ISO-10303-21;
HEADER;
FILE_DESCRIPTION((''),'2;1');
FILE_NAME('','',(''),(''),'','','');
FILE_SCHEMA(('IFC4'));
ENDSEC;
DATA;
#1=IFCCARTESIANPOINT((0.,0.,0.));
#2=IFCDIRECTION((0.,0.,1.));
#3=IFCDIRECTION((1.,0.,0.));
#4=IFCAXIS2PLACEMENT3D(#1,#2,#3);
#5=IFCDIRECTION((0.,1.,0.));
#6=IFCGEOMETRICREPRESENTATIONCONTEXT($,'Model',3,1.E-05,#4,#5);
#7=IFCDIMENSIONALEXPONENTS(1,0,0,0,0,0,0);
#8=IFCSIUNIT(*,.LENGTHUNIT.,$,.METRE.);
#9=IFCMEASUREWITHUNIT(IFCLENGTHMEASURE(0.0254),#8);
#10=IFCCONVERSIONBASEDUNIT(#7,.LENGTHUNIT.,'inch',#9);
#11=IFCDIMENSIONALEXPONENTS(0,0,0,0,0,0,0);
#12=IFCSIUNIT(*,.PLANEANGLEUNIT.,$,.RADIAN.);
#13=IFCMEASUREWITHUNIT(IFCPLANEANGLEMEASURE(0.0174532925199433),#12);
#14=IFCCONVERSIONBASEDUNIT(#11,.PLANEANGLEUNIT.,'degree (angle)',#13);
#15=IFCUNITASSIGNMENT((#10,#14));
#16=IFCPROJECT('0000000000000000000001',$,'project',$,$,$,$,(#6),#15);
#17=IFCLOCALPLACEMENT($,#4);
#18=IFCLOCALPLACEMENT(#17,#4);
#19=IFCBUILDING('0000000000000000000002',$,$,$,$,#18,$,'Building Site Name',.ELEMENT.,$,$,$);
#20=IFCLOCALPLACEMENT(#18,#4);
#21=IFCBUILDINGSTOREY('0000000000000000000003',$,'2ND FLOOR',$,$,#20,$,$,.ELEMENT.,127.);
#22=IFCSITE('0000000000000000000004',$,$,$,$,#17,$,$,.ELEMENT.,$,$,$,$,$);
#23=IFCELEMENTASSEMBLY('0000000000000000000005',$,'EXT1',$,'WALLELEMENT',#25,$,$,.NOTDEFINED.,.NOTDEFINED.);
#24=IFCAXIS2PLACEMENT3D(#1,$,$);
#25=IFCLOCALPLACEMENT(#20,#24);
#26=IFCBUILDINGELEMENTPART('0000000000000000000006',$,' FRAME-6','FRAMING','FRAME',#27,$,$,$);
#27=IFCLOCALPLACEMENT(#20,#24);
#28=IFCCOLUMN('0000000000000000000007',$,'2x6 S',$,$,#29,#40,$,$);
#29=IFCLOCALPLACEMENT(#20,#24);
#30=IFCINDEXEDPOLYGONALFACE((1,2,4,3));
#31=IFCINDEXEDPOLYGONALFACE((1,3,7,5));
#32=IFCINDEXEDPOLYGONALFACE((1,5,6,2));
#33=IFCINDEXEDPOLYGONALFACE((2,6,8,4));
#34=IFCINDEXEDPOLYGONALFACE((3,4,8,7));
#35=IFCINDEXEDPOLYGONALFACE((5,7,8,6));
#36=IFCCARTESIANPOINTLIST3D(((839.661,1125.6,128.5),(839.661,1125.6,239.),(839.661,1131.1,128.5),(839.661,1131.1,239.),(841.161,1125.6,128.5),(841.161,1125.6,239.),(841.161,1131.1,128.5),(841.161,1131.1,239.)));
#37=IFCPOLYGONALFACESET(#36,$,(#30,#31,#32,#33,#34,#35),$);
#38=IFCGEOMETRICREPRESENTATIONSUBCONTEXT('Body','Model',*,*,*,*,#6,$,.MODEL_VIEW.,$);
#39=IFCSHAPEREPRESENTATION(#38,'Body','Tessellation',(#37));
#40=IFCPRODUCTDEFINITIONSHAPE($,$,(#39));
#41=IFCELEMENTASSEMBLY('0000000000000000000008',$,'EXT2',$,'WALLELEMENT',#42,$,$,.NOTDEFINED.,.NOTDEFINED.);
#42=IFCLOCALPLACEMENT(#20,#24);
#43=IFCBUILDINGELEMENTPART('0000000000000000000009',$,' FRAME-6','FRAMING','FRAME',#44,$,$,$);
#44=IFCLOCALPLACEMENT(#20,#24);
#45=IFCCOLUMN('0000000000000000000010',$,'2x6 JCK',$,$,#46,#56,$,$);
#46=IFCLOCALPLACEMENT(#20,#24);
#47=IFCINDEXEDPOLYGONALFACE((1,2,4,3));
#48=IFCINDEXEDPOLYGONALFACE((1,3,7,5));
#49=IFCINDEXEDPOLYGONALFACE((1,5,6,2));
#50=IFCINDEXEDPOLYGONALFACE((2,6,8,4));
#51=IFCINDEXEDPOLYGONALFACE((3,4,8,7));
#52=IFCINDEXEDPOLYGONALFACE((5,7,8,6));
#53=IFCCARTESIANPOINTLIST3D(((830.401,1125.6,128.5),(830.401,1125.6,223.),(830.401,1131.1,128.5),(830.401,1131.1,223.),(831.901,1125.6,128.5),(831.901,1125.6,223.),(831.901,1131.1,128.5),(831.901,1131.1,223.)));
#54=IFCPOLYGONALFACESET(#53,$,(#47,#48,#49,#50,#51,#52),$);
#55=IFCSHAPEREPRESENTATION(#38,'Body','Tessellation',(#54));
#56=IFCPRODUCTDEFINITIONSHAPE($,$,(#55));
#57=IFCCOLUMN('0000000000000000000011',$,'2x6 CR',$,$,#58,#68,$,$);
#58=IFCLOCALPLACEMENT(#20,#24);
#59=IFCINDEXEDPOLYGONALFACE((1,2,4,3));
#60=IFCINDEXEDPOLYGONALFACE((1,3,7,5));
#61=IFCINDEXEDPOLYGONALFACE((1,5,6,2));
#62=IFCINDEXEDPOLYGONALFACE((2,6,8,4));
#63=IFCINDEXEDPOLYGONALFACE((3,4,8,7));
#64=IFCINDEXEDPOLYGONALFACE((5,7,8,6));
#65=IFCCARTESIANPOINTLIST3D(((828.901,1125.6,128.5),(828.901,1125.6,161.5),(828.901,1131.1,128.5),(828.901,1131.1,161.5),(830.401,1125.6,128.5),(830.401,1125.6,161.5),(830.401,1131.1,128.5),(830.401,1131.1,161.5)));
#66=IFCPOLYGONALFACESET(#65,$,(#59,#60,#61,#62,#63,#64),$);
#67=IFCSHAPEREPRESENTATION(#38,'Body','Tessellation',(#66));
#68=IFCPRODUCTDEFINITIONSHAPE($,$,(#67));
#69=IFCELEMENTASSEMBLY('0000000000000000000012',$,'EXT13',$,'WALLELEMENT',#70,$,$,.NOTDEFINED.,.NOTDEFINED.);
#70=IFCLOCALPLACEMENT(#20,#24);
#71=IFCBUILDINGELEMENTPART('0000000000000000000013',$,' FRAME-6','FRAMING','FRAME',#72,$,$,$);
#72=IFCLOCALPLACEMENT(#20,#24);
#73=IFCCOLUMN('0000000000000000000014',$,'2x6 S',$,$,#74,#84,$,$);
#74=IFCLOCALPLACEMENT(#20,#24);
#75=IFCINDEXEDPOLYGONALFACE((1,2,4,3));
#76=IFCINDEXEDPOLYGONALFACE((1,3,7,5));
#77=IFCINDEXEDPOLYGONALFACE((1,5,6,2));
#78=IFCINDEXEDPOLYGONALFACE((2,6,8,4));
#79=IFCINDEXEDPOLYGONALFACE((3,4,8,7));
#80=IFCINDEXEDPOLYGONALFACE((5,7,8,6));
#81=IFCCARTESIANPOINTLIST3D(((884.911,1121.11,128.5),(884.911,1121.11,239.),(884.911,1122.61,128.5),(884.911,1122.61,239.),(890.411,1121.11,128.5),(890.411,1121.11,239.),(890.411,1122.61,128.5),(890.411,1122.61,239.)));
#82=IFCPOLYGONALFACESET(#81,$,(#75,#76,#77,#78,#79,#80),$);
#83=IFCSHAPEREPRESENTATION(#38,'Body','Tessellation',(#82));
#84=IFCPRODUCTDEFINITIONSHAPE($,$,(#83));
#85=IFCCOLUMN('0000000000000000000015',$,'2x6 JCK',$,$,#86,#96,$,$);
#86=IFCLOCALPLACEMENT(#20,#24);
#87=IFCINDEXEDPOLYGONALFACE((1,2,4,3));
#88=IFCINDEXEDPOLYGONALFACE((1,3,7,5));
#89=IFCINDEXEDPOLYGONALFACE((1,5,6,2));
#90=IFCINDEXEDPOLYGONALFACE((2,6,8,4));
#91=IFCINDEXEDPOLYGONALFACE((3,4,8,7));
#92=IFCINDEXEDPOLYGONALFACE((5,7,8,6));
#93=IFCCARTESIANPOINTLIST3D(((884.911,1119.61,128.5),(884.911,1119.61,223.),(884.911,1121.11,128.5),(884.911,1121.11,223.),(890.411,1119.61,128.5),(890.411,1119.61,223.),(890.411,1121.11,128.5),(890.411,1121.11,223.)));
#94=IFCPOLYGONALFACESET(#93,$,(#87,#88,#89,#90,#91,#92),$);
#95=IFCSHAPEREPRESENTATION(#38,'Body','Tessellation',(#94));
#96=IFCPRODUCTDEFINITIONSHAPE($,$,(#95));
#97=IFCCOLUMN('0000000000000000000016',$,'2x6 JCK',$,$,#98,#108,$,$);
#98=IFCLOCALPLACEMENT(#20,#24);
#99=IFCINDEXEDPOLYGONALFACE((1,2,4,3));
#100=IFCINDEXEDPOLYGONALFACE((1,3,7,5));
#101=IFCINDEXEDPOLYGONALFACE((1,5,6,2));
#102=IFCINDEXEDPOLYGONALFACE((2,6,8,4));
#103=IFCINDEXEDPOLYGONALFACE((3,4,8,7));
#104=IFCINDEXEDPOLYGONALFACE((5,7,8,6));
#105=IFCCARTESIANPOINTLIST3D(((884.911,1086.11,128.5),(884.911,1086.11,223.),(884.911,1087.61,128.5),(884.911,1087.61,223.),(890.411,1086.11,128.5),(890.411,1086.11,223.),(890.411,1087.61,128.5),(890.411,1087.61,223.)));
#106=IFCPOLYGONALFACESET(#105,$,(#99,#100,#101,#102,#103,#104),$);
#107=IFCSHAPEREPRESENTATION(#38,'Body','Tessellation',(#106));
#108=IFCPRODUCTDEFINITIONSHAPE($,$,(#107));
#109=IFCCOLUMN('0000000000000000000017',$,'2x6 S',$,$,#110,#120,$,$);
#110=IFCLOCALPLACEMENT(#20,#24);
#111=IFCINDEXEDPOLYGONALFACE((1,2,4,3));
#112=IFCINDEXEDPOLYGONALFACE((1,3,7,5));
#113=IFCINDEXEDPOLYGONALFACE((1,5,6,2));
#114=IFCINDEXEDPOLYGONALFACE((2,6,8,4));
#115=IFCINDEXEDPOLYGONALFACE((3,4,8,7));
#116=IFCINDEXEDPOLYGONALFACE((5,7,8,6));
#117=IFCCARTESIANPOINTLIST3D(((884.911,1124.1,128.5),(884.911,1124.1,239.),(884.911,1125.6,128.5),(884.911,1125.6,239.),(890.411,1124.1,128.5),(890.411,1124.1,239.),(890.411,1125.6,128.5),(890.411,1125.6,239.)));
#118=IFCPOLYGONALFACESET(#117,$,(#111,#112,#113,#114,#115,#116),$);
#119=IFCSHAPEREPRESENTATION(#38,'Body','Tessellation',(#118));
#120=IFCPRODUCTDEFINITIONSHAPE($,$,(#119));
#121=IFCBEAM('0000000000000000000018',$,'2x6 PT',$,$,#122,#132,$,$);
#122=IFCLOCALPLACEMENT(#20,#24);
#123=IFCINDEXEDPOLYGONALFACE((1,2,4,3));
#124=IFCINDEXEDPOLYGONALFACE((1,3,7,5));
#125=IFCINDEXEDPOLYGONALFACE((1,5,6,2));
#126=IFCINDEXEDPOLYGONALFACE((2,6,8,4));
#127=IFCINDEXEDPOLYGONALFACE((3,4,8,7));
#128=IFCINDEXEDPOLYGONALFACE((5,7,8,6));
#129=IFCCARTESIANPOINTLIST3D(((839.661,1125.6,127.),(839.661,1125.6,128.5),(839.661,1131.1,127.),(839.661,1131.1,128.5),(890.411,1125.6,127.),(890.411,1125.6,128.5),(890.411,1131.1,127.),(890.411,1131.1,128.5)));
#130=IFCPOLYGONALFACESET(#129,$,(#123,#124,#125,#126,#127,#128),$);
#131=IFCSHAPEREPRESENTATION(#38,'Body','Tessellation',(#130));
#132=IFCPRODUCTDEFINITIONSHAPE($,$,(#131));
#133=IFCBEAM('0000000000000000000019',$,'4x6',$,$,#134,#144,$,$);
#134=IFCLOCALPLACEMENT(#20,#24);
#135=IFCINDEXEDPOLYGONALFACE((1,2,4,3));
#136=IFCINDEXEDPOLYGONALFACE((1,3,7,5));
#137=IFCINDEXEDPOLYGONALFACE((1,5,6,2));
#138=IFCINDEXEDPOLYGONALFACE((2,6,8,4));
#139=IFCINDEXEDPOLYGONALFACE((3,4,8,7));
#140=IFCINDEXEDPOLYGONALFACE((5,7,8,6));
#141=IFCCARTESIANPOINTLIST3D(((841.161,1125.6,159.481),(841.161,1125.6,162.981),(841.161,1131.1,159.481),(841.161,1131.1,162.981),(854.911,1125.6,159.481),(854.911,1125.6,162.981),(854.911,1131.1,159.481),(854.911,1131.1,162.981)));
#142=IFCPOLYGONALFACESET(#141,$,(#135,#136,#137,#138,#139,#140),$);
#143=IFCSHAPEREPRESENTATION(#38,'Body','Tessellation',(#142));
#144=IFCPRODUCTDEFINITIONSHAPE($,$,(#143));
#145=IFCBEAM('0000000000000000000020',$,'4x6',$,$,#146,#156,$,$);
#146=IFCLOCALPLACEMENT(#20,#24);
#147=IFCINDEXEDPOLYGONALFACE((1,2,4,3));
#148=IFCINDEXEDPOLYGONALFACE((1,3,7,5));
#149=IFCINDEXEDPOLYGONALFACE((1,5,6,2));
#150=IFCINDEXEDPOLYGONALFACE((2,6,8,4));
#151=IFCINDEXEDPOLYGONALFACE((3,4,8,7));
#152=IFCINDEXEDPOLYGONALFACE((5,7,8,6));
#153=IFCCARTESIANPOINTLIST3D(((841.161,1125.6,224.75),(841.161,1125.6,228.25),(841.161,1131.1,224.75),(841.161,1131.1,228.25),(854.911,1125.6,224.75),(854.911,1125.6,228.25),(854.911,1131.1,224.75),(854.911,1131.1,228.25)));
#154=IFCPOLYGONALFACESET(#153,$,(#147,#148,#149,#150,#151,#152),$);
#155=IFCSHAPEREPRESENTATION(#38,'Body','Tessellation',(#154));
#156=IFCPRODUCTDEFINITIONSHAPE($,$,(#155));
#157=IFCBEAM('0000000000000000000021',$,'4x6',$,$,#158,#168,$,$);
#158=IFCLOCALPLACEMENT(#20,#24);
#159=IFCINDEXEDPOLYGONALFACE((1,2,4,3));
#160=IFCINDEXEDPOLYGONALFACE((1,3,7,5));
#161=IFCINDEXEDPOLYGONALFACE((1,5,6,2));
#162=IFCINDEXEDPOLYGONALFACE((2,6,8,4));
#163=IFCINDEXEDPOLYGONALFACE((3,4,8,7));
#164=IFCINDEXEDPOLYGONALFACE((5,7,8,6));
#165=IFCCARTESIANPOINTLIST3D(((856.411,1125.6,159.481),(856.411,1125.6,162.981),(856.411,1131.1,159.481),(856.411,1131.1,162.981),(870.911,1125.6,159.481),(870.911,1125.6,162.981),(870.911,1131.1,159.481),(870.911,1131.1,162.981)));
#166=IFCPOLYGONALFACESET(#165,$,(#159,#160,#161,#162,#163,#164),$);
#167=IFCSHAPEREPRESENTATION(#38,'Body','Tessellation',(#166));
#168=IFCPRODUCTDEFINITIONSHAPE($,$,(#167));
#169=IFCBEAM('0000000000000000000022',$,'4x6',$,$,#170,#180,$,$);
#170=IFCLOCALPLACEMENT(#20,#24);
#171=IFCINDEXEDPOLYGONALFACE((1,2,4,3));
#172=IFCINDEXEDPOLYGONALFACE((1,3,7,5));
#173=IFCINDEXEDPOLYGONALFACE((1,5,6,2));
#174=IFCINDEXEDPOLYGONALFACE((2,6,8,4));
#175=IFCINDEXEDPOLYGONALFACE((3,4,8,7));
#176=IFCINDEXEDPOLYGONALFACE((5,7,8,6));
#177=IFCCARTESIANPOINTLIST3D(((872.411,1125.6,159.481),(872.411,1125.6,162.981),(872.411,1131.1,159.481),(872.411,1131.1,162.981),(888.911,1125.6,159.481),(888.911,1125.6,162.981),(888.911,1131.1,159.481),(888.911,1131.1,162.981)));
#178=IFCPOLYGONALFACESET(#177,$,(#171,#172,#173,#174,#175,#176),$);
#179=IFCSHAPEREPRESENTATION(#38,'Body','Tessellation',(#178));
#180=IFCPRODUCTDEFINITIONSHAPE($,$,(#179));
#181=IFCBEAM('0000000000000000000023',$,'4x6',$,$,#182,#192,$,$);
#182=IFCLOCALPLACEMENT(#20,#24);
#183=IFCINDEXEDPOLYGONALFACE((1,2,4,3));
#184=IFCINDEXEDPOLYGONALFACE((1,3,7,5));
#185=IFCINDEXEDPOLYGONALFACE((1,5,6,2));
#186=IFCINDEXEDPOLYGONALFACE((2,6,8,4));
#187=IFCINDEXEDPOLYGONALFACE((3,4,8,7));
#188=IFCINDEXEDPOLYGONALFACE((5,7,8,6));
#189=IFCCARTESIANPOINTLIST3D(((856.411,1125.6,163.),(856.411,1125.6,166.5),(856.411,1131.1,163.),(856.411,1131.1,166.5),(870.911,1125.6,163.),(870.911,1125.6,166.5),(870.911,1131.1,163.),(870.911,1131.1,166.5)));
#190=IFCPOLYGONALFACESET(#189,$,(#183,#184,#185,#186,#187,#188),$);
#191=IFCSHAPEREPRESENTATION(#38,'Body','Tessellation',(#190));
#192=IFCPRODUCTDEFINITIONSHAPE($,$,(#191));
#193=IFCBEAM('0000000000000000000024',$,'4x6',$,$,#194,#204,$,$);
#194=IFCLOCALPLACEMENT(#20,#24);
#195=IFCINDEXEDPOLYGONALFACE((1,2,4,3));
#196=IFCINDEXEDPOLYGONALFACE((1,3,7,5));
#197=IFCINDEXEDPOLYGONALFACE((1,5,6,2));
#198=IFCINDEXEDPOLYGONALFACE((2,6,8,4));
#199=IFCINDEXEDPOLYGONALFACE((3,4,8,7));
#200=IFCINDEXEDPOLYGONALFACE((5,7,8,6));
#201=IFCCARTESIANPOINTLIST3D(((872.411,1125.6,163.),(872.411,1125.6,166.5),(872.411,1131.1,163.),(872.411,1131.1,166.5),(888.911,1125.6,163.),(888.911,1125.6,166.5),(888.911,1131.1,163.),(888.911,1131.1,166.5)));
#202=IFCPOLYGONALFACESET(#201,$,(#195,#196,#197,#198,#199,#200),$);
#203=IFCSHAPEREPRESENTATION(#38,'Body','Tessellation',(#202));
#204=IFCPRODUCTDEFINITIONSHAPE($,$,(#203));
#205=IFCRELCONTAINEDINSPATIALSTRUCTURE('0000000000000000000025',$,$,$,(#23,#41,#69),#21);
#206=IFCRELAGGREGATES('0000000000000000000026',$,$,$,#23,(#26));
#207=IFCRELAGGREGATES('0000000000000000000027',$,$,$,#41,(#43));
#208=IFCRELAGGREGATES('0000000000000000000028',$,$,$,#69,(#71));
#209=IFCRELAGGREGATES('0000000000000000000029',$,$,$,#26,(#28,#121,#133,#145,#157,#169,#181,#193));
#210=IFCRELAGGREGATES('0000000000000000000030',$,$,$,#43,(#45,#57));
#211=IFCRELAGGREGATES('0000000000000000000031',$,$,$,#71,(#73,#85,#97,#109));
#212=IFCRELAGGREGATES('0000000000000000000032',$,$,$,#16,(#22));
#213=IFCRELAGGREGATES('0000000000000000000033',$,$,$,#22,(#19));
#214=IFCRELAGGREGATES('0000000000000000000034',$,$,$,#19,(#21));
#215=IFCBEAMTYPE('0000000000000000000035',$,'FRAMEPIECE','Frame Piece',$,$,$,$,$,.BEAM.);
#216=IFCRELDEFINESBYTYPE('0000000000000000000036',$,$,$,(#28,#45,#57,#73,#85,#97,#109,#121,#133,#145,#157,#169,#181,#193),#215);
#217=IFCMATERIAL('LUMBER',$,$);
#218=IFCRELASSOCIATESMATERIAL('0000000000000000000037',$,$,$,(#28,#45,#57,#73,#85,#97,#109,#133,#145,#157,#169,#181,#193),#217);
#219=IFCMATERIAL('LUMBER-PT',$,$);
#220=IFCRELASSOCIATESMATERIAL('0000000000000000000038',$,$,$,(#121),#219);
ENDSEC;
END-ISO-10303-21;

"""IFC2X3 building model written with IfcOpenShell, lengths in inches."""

from ifc_helpers import new_model, entity, si_unit, converted_unit, direction, frame, frame_2d, origin_with_axes, place, context, subcontext, project, spatial, polyline, segment, composite_curve, rectangle, outline, extrude, material, type_object, element, aggregate, save


model = new_model("IFC2X3")

# Units and contexts
model_context = context("Model", 3, precision=1e-05, world=origin_with_axes(), true_north=direction((0.0, 1.0, 0.0)))
body_context = subcontext(model_context, "Body", "Model", "MODEL_VIEW")
ifc_project = project(units=[converted_unit("LENGTHUNIT", "inch", entity("IfcLengthMeasure", 0.0254), si_unit("LENGTHUNIT", "METRE"), dimensions=[1, 0, 0, 0, 0, 0, 0]), converted_unit("PLANEANGLEUNIT", "degree (angle)", entity("IfcPlaneAngleMeasure", 0.0174532925199433), si_unit("PLANEANGLEUNIT", "RADIAN"), dimensions=[0, 0, 0, 0, 0, 0, 0])], contexts=[model_context])

# Site, building, storey
site_placement = place(None, origin_with_axes())
site = spatial("IfcSite", under=ifc_project, at=site_placement, CompositionType="ELEMENT")
building_placement = place(site_placement, origin_with_axes())
building = spatial("IfcBuilding", under=site, at=building_placement, LongName="Building Site Name", CompositionType="ELEMENT")
storey_placement = place(building_placement, origin_with_axes())
storey = spatial("IfcBuildingStorey", under=building, at=storey_placement, Name="2ND FLOOR", CompositionType="ELEMENT", Elevation=127.0)

# Element assembly, building element part, column
assembly_1_placement = place(storey_placement, origin_with_axes())
assembly_1 = element("IfcElementAssembly", 1, at=assembly_1_placement, inside=storey, Name="EXT1", ObjectType="WALLELEMENT", AssemblyPlace="NOTDEFINED", PredefinedType="NOTDEFINED")
building_element_part_1 = element("IfcBuildingElementPart", 2, Name=" FRAME-6", Description="FRAMING", ObjectType="FRAME")
aggregate(assembly_1, [building_element_part_1])
ifc_material_1 = material(Name="LUMBER")
beam_type = type_object("IfcBeamType", Name="FRAMEPIECE", Description="Frame Piece", PredefinedType="BEAM")
column_1_placement = place(assembly_1_placement, frame((840.411, 1128.35, 128.5), z_axis=(0.0, 0.0, 1.0), x_axis=(1.0, 0.0, 0.0)))
column_1 = element("IfcColumn", 3, at=column_1_placement, type_object=beam_type, material=ifc_material_1, Name="2x6 S", context=body_context, shape_type="SweptSolid", body=[
    extrude(rectangle(XDim=1.5, YDim=5.5, at=frame_2d((0.0, 0.0), x_axis=(-1.0, 0.0))), origin_with_axes(), (0.0, 0.0, 1.0), 110.5),
])

# Element assemblies, building element parts, columns
assembly_2_placement = place(storey_placement, origin_with_axes())
assembly_2 = element("IfcElementAssembly", 4, at=assembly_2_placement, inside=storey, Name="EXT2", ObjectType="WALLELEMENT", AssemblyPlace="NOTDEFINED", PredefinedType="NOTDEFINED")
building_element_part_2 = element("IfcBuildingElementPart", 5, Name=" FRAME-6", Description="FRAMING", ObjectType="FRAME")
aggregate(assembly_2, [building_element_part_2])
column_2_placement = place(assembly_2_placement, frame((831.151, 1128.35, 223.0), z_axis=(0.0, 0.0, -1.0), x_axis=(-1.0, 0.0, 0.0)))
column_2 = element("IfcColumn", 6, at=column_2_placement, type_object=beam_type, material=ifc_material_1, Name="2x6 JCK", context=body_context, shape_type="SweptSolid", body=[
    extrude(rectangle(XDim=1.5, YDim=5.5, at=frame_2d((0.0, 0.0), x_axis=(-1.0, 0.0))), origin_with_axes(), (0.0, 0.0, 1.0), 94.5),
])
column_3_placement = place(assembly_2_placement, frame((829.651, 1128.35, 161.5), z_axis=(0.0, 0.0, -1.0), x_axis=(-1.0, 0.0, 0.0)))
column_3 = element("IfcColumn", 7, at=column_3_placement, type_object=beam_type, material=ifc_material_1, Name="2x6 CR", context=body_context, shape_type="SweptSolid", body=[
    extrude(rectangle(XDim=1.5, YDim=5.5, at=frame_2d((0.0, 0.0), x_axis=(-1.0, 0.0))), origin_with_axes(), (0.0, 0.0, 1.0), 33.0),
])
assembly_3_placement = place(storey_placement, origin_with_axes())
assembly_3 = element("IfcElementAssembly", 8, at=assembly_3_placement, inside=storey, Name="EXT13", ObjectType="WALLELEMENT", AssemblyPlace="NOTDEFINED", PredefinedType="NOTDEFINED")
building_element_part_3 = element("IfcBuildingElementPart", 9, Name=" FRAME-6", Description="FRAMING", ObjectType="FRAME")
aggregate(assembly_3, [building_element_part_3])
column_4_placement = place(assembly_3_placement, frame((887.661, 1121.86, 128.5), z_axis=(0.0, 0.0, 1.0), x_axis=(0.0, -1.0, 0.0)))
column_4 = element("IfcColumn", 10, at=column_4_placement, type_object=beam_type, material=ifc_material_1, Name="2x6 S", context=body_context, shape_type="SweptSolid", body=[
    extrude(rectangle(XDim=1.5, YDim=5.5, at=frame_2d((0.0, 0.0), x_axis=(-1.0, 0.0))), origin_with_axes(), (0.0, 0.0, 1.0), 110.5),
])
column_5_placement = place(assembly_3_placement, frame((887.661, 1120.36, 128.5), z_axis=(0.0, 0.0, 1.0), x_axis=(0.0, -1.0, 0.0)))
column_5 = element("IfcColumn", 11, at=column_5_placement, type_object=beam_type, material=ifc_material_1, Name="2x6 JCK", context=body_context, shape_type="SweptSolid", body=[
    extrude(rectangle(XDim=1.5, YDim=5.5, at=frame_2d((0.0, 0.0), x_axis=(-1.0, 0.0))), origin_with_axes(), (0.0, 0.0, 1.0), 94.5),
])
column_6_placement = place(assembly_3_placement, frame((887.661, 1086.86, 223.0), z_axis=(0.0, 0.0, -1.0), x_axis=(0.0, 1.0, 0.0)))
column_6 = element("IfcColumn", 12, at=column_6_placement, type_object=beam_type, material=ifc_material_1, Name="2x6 JCK", context=body_context, shape_type="SweptSolid", body=[
    extrude(rectangle(XDim=1.5, YDim=5.5, at=frame_2d((0.0, 0.0), x_axis=(-1.0, 0.0))), origin_with_axes(), (0.0, 0.0, 1.0), 94.5),
])
column_7_placement = place(assembly_3_placement, frame((887.661, 1124.85, 128.5), z_axis=(0.0, 0.0, 1.0), x_axis=(0.0, -1.0, 0.0)))
column_7 = element("IfcColumn", 13, at=column_7_placement, type_object=beam_type, material=ifc_material_1, Name="2x6 S", context=body_context, shape_type="SweptSolid", body=[
    extrude(rectangle(XDim=1.5, YDim=5.5, at=frame_2d((0.0, 0.0), x_axis=(-1.0, 0.0))), origin_with_axes(), (0.0, 0.0, 1.0), 110.5),
])

# Beams
ifc_material_2 = material(Name="LUMBER-PT")
beam_1_placement = place(assembly_1_placement, frame((890.411, 1128.35, 127.75), z_axis=(-1.0, 0.0, 0.0), x_axis=(0.0, 0.0, 1.0)))
beam_1 = element("IfcBeam", 14, at=beam_1_placement, type_object=beam_type, material=ifc_material_2, Name="2x6 PT", context=body_context, shape_type="SweptSolid", body=[
    extrude(rectangle(XDim=1.5, YDim=5.5, at=frame_2d((0.0, 0.0), x_axis=(-1.0, 0.0))), origin_with_axes(), (0.0, 0.0, 1.0), 50.75),
])
beam_2_placement = place(assembly_1_placement, frame((841.161, 1128.35, 161.231), z_axis=(1.0, 0.0, 0.0), x_axis=(0.0, 0.0, -1.0)))
beam_2 = element("IfcBeam", 15, at=beam_2_placement, type_object=beam_type, material=ifc_material_1, Name="4x6", context=body_context, shape_type="SweptSolid", body=[
    extrude(outline(composite_curve([segment(polyline([(-1.75, -2.75), (-1.75, 2.75), (1.75, 2.75), (1.75, -2.75), (-1.75, -2.75)]), True, "CONTINUOUS")], self_intersect=False)), origin_with_axes(), (0.0, 0.0, 1.0), 13.75),
])
beam_3_placement = place(assembly_1_placement, frame((841.161, 1128.35, 226.5), z_axis=(1.0, 0.0, 0.0), x_axis=(0.0, 0.0, -1.0)))
beam_3 = element("IfcBeam", 16, at=beam_3_placement, type_object=beam_type, material=ifc_material_1, Name="4x6", context=body_context, shape_type="SweptSolid", body=[
    extrude(outline(composite_curve([segment(polyline([(-1.75, -2.75), (-1.75, 2.75), (1.75, 2.75), (1.75, -2.75), (-1.75, -2.75)]), True, "CONTINUOUS")], self_intersect=False)), origin_with_axes(), (0.0, 0.0, 1.0), 13.75),
])
beam_4_placement = place(assembly_1_placement, frame((856.411, 1128.35, 161.231), z_axis=(1.0, 0.0, 0.0), x_axis=(0.0, 0.0, -1.0)))
beam_4 = element("IfcBeam", 17, at=beam_4_placement, type_object=beam_type, material=ifc_material_1, Name="4x6", context=body_context, shape_type="SweptSolid", body=[
    extrude(outline(composite_curve([segment(polyline([(-1.75, -2.75), (-1.75, 2.75), (1.75, 2.75), (1.75, -2.75), (-1.75, -2.75)]), True, "CONTINUOUS")], self_intersect=False)), origin_with_axes(), (0.0, 0.0, 1.0), 14.5),
])
beam_5_placement = place(assembly_1_placement, frame((872.411, 1128.35, 161.231), z_axis=(1.0, 0.0, 0.0), x_axis=(0.0, 0.0, -1.0)))
beam_5 = element("IfcBeam", 18, at=beam_5_placement, type_object=beam_type, material=ifc_material_1, Name="4x6", context=body_context, shape_type="SweptSolid", body=[
    extrude(outline(composite_curve([segment(polyline([(-1.75, -2.75), (-1.75, 2.75), (1.75, 2.75), (1.75, -2.75), (-1.75, -2.75)]), True, "CONTINUOUS")], self_intersect=False)), origin_with_axes(), (0.0, 0.0, 1.0), 16.5),
])
beam_6_placement = place(assembly_1_placement, frame((856.411, 1128.35, 164.75), z_axis=(1.0, 0.0, 0.0), x_axis=(0.0, 0.0, -1.0)))
beam_6 = element("IfcBeam", 19, at=beam_6_placement, type_object=beam_type, material=ifc_material_1, Name="4x6", context=body_context, shape_type="SweptSolid", body=[
    extrude(outline(composite_curve([segment(polyline([(-1.75, -2.75), (-1.75, 2.75), (1.75, 2.75), (1.75, -2.75), (-1.75, -2.75)]), True, "CONTINUOUS")], self_intersect=False)), origin_with_axes(), (0.0, 0.0, 1.0), 14.5),
])
beam_7_placement = place(assembly_1_placement, frame((872.411, 1128.35, 164.75), z_axis=(1.0, 0.0, 0.0), x_axis=(0.0, 0.0, -1.0)))
beam_7 = element("IfcBeam", 20, at=beam_7_placement, type_object=beam_type, material=ifc_material_1, Name="4x6", context=body_context, shape_type="SweptSolid", body=[
    extrude(outline(composite_curve([segment(polyline([(-1.75, -2.75), (-1.75, 2.75), (1.75, 2.75), (1.75, -2.75), (-1.75, -2.75)]), True, "CONTINUOUS")], self_intersect=False)), origin_with_axes(), (0.0, 0.0, 1.0), 16.5),
])
aggregate(building_element_part_1, [column_1, beam_1, beam_2, beam_3, beam_4, beam_5, beam_6, beam_7])
aggregate(building_element_part_2, [column_2, column_3])
aggregate(building_element_part_3, [column_4, column_5, column_6, column_7])

save(model, "model.ifc")
